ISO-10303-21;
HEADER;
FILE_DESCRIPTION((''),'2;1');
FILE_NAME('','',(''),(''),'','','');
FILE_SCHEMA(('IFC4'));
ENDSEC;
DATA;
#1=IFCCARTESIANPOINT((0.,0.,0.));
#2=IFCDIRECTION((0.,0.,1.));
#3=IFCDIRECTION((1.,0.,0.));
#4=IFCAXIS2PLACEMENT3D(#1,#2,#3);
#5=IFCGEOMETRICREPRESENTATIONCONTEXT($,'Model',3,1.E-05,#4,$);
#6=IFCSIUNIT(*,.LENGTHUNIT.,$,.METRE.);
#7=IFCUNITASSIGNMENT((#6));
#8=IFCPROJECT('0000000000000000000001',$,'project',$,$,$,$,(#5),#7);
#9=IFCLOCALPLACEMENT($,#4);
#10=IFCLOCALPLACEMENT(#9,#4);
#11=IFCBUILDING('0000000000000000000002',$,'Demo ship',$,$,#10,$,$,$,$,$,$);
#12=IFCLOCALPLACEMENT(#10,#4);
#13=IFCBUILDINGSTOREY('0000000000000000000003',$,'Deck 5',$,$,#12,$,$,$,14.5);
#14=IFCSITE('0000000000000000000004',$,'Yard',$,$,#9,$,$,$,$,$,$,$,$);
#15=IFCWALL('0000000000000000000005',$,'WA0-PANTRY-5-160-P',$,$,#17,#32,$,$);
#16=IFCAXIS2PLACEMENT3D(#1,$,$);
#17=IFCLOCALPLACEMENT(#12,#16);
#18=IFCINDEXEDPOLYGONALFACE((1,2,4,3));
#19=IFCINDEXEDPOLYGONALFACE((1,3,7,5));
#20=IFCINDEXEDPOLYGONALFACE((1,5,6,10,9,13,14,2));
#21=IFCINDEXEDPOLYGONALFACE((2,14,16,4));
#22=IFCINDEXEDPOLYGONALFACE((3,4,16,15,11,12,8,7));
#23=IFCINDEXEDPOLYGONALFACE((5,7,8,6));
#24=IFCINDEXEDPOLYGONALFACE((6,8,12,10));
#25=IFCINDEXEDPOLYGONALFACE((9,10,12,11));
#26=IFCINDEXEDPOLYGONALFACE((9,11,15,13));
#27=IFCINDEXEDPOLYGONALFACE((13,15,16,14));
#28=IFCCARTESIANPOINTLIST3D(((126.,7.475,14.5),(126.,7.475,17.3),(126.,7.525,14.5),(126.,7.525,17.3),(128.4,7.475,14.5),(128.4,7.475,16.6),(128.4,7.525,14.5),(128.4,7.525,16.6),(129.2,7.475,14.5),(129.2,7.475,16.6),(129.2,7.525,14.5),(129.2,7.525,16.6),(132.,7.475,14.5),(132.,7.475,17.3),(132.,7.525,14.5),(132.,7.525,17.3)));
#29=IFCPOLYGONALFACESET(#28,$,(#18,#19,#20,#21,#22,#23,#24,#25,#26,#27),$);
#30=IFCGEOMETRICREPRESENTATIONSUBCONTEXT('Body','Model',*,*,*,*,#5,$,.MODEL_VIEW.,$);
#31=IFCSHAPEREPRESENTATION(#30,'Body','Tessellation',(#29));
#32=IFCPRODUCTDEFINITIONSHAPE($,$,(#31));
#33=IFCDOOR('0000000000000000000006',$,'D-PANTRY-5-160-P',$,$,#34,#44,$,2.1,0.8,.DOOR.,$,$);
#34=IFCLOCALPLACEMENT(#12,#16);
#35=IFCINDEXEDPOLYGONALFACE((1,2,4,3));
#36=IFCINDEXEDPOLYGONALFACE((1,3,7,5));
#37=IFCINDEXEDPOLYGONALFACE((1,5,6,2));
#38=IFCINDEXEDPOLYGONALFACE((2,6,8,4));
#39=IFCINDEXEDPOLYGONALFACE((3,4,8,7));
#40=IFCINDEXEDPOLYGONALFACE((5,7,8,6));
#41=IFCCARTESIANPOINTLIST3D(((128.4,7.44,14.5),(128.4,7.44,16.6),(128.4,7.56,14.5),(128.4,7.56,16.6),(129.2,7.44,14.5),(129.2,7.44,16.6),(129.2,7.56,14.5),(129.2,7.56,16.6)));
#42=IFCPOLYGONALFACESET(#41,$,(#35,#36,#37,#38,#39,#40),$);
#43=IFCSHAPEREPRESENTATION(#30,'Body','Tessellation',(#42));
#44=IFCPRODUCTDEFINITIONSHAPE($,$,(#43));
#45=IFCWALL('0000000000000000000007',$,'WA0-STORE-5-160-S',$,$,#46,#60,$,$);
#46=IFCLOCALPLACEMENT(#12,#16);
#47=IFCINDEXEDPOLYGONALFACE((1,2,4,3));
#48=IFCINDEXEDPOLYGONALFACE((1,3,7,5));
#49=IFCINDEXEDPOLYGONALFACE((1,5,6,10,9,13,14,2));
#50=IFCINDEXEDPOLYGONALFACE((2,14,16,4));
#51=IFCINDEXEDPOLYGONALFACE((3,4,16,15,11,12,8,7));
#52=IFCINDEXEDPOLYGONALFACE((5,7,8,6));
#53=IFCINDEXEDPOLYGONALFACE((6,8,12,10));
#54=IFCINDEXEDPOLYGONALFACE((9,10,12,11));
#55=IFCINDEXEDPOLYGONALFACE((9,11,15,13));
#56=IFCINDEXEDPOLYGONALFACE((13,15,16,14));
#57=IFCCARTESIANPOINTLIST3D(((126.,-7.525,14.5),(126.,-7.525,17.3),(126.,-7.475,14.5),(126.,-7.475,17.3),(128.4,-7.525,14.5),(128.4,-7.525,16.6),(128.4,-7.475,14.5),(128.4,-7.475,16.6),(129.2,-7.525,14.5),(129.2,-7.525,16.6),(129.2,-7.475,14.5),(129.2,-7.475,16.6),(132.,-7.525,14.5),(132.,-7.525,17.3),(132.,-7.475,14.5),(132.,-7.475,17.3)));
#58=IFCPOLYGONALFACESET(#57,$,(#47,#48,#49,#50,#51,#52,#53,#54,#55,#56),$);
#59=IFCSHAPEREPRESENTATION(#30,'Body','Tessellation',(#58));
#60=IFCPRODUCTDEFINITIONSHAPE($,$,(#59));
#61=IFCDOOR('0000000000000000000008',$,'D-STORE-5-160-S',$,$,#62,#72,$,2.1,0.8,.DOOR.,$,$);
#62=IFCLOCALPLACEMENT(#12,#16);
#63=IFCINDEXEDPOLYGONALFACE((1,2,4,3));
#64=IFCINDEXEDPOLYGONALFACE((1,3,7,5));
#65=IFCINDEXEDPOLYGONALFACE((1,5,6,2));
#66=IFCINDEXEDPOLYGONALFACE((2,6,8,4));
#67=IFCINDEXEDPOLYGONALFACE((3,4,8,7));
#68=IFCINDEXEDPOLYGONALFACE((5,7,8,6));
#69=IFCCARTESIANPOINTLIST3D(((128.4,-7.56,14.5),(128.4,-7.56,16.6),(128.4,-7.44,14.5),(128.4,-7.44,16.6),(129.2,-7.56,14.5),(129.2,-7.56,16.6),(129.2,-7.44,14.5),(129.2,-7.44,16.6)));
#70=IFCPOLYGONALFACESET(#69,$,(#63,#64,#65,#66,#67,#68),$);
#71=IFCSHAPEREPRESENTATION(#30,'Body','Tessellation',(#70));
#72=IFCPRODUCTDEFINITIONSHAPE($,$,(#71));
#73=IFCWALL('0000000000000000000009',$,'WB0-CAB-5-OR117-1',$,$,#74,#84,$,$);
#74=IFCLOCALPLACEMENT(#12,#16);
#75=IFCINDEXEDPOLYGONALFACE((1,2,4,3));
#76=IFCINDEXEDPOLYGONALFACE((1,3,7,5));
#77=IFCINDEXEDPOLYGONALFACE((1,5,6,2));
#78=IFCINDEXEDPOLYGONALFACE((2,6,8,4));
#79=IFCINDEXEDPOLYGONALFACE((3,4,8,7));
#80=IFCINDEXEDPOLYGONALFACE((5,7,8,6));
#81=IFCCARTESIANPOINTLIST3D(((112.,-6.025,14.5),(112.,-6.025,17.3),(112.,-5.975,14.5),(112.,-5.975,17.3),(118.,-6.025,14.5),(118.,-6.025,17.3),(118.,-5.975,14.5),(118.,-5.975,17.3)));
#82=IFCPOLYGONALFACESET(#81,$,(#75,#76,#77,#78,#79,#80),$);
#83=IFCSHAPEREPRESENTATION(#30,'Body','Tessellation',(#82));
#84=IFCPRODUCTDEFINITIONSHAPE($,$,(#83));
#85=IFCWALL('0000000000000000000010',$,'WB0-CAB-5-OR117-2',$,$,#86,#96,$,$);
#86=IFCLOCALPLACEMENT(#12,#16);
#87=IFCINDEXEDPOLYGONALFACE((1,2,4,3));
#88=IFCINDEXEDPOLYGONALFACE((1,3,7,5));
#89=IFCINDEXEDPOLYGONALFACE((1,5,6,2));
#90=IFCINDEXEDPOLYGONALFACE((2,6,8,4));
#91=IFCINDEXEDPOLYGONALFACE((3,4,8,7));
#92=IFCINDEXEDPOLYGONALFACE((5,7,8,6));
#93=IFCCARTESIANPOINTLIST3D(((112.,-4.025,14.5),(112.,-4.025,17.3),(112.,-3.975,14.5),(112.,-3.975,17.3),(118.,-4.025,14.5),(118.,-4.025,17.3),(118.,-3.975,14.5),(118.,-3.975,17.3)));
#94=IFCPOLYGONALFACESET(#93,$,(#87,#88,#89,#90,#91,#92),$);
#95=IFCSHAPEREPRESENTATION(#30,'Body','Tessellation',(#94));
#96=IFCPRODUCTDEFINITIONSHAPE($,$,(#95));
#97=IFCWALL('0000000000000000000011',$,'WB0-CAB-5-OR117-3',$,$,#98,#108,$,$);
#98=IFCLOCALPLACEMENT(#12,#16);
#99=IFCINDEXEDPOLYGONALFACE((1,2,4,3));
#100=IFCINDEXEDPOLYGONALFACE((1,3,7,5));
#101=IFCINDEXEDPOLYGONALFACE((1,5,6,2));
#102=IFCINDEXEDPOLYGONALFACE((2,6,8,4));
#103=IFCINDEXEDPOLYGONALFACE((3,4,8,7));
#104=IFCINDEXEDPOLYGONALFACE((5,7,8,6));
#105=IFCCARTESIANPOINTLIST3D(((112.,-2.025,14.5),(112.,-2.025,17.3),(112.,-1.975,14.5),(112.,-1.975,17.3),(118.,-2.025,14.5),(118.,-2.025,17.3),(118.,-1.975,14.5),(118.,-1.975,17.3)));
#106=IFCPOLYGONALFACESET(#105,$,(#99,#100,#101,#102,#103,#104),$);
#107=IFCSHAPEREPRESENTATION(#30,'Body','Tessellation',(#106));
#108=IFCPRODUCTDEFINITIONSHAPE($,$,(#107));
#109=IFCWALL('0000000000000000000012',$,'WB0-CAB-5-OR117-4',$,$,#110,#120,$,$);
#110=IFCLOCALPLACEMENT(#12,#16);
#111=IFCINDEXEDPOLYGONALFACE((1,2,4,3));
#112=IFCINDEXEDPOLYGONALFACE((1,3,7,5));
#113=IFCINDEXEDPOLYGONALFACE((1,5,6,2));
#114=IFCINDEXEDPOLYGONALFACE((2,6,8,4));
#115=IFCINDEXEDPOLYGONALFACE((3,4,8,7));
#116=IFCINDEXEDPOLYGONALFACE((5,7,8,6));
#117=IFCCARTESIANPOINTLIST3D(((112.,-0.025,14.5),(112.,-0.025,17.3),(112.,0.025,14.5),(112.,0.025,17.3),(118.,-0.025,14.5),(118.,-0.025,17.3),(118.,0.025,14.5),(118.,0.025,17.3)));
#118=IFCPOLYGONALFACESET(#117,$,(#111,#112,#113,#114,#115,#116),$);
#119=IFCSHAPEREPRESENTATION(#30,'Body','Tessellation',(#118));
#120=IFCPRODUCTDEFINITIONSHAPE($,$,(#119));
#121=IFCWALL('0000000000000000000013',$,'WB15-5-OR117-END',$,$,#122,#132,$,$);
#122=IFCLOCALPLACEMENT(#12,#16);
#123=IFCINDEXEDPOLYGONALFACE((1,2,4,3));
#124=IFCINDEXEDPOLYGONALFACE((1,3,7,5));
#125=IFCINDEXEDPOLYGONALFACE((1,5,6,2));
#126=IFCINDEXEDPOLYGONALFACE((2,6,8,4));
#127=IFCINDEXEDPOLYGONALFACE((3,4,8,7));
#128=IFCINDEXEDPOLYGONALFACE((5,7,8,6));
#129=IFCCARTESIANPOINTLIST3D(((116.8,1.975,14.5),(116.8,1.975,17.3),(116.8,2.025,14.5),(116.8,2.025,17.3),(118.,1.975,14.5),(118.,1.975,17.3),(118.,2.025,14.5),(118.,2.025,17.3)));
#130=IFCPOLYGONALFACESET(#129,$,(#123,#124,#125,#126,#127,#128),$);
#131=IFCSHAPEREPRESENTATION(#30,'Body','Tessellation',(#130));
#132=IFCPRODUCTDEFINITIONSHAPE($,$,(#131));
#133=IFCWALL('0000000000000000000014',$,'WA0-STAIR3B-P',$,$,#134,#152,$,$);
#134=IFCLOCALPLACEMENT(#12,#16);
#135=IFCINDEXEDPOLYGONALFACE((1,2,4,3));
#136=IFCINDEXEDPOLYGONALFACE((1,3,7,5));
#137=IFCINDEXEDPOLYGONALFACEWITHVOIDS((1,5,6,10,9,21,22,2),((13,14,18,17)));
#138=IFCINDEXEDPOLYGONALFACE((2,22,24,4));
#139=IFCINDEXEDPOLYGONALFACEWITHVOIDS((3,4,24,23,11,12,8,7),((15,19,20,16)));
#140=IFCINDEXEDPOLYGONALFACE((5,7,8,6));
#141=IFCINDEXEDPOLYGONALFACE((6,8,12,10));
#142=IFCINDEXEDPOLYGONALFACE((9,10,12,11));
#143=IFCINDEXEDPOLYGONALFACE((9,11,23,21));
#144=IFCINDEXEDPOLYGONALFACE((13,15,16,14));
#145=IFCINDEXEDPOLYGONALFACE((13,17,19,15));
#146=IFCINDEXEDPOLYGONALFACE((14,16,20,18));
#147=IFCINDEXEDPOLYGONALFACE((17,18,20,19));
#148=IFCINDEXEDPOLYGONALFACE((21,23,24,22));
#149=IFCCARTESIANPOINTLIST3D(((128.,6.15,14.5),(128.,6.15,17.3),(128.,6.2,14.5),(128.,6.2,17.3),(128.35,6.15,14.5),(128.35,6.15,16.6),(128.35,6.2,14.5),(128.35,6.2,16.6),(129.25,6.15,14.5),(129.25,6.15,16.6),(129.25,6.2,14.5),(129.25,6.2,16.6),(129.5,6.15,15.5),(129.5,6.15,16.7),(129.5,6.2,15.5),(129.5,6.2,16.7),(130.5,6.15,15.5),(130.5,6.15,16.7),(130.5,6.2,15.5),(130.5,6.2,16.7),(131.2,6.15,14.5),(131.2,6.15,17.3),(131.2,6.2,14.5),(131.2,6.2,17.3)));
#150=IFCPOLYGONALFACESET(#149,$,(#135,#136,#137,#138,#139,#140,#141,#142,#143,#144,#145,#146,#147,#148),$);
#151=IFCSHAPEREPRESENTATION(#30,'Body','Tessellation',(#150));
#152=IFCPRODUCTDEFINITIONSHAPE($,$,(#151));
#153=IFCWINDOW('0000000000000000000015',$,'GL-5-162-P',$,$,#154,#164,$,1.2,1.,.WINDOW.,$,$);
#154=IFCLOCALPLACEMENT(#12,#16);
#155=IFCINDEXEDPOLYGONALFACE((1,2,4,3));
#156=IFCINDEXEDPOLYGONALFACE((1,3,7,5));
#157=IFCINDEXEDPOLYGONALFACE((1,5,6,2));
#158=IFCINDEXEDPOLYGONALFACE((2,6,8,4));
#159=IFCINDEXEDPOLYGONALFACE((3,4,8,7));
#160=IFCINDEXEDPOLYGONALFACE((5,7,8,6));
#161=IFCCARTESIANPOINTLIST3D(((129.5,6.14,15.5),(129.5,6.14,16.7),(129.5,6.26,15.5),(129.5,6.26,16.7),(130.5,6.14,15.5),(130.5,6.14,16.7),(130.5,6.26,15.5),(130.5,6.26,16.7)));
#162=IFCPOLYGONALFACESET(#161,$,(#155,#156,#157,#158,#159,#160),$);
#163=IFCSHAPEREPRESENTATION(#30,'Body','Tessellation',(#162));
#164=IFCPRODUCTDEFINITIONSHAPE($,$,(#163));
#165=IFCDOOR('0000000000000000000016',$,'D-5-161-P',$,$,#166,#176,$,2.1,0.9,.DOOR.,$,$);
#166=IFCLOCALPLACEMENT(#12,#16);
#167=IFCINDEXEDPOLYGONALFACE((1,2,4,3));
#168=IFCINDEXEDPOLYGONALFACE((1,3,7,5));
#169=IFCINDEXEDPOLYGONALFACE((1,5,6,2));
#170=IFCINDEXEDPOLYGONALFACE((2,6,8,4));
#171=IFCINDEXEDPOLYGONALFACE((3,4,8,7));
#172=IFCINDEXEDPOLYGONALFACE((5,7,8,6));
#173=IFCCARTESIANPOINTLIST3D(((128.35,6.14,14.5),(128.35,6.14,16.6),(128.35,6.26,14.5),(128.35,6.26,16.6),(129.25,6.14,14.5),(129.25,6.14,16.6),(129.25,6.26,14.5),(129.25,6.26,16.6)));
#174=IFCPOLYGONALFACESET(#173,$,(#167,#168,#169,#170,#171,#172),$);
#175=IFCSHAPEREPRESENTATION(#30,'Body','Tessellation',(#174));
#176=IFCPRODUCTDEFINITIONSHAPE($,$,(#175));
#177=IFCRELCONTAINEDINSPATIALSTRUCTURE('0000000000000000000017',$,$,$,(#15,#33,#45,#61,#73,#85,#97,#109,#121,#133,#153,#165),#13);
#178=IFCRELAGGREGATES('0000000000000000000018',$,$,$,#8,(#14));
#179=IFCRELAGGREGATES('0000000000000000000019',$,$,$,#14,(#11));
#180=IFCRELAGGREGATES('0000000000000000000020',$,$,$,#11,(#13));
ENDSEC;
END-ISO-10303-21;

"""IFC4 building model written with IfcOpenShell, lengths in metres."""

from ifc_helpers import new_model, si_unit, frame, frame_2d, origin, origin_with_axes, place, context, subcontext, project, spatial, rectangle, extrude, element, fill, save


model = new_model("IFC4")

# Units and contexts
model_context = context("Model", 3, precision=1e-05, world=origin_with_axes())
body_context = subcontext(model_context, "Body", "Model", "MODEL_VIEW")
ifc_project = project(units=[si_unit("LENGTHUNIT", "METRE")], contexts=[model_context])

# Site, building, storey
site_placement = place(None, origin_with_axes())
site = spatial("IfcSite", under=ifc_project, at=site_placement, Name="Yard")
building_placement = place(site_placement, origin_with_axes())
building = spatial("IfcBuilding", under=site, at=building_placement, Name="Demo ship")
storey_placement = place(building_placement, origin_with_axes())
storey = spatial("IfcBuildingStorey", under=building, at=storey_placement, Name="Deck 5", Elevation=14.5)

# Walls, openings, doors
wall_1_placement = place(storey_placement, frame((126.0, 7.475, 14.5), z_axis=(0.0, 0.0, 1.0), x_axis=(1.0, 0.0, 0.0)))
wall_1 = element("IfcWall", 1, at=wall_1_placement, inside=storey, Name="WA0-PANTRY-5-160-P", context=body_context, shape_type="SweptSolid", body=[
    extrude(rectangle(XDim=6.0, YDim=0.05, at=frame_2d((3.0, 0.025))), origin(), (0.0, 0.0, 1.0), 2.8),
])
opening_1_placement = place(None, frame((128.4, 7.44, 14.5), z_axis=(0.0, 0.0, 1.0), x_axis=(1.0, 0.0, 0.0)))
opening_1 = element("IfcOpeningElement", 2, at=opening_1_placement, cuts=wall_1, context=body_context, shape_type="SweptSolid", body=[
    extrude(rectangle(XDim=0.8, YDim=0.12, at=frame_2d((0.4, 0.06))), origin(), (0.0, 0.0, 1.0), 2.1),
])
door_1_placement = place(storey_placement, frame((128.4, 7.44, 14.5), z_axis=(0.0, 0.0, 1.0), x_axis=(1.0, 0.0, 0.0)))
door_1 = element("IfcDoor", 3, at=door_1_placement, inside=storey, Name="D-PANTRY-5-160-P", OverallHeight=2.1, OverallWidth=0.8, PredefinedType="DOOR", context=body_context, shape_type="SweptSolid", body=[
    extrude(rectangle(XDim=0.8, YDim=0.12, at=frame_2d((0.4, 0.06))), origin(), (0.0, 0.0, 1.0), 2.1),
])
fill(opening_1, door_1)
wall_2_placement = place(storey_placement, frame((126.0, -7.525, 14.5), z_axis=(0.0, 0.0, 1.0), x_axis=(1.0, 0.0, 0.0)))
wall_2 = element("IfcWall", 4, at=wall_2_placement, inside=storey, Name="WA0-STORE-5-160-S", context=body_context, shape_type="SweptSolid", body=[
    extrude(rectangle(XDim=6.0, YDim=0.05, at=frame_2d((3.0, 0.025))), origin(), (0.0, 0.0, 1.0), 2.8),
])
opening_2_placement = place(None, frame((128.4, -7.56, 14.5), z_axis=(0.0, 0.0, 1.0), x_axis=(1.0, 0.0, 0.0)))
opening_2 = element("IfcOpeningElement", 5, at=opening_2_placement, cuts=wall_2, context=body_context, shape_type="SweptSolid", body=[
    extrude(rectangle(XDim=0.8, YDim=0.12, at=frame_2d((0.4, 0.06))), origin(), (0.0, 0.0, 1.0), 2.1),
])
door_2_placement = place(storey_placement, frame((128.4, -7.56, 14.5), z_axis=(0.0, 0.0, 1.0), x_axis=(1.0, 0.0, 0.0)))
door_2 = element("IfcDoor", 6, at=door_2_placement, inside=storey, Name="D-STORE-5-160-S", OverallHeight=2.1, OverallWidth=0.8, PredefinedType="DOOR", context=body_context, shape_type="SweptSolid", body=[
    extrude(rectangle(XDim=0.8, YDim=0.12, at=frame_2d((0.4, 0.06))), origin(), (0.0, 0.0, 1.0), 2.1),
])
fill(opening_2, door_2)

# Walls
wall_3_placement = place(storey_placement, frame((112.0, -6.025, 14.5), z_axis=(0.0, 0.0, 1.0), x_axis=(1.0, 0.0, 0.0)))
element("IfcWall", 7, at=wall_3_placement, inside=storey, Name="WB0-CAB-5-OR117-1", context=body_context, shape_type="SweptSolid", body=[
    extrude(rectangle(XDim=6.0, YDim=0.05, at=frame_2d((3.0, 0.025))), origin(), (0.0, 0.0, 1.0), 2.8),
])
wall_4_placement = place(storey_placement, frame((112.0, -4.025, 14.5), z_axis=(0.0, 0.0, 1.0), x_axis=(1.0, 0.0, 0.0)))
element("IfcWall", 8, at=wall_4_placement, inside=storey, Name="WB0-CAB-5-OR117-2", context=body_context, shape_type="SweptSolid", body=[
    extrude(rectangle(XDim=6.0, YDim=0.05, at=frame_2d((3.0, 0.025))), origin(), (0.0, 0.0, 1.0), 2.8),
])
wall_5_placement = place(storey_placement, frame((112.0, -2.025, 14.5), z_axis=(0.0, 0.0, 1.0), x_axis=(1.0, 0.0, 0.0)))
element("IfcWall", 9, at=wall_5_placement, inside=storey, Name="WB0-CAB-5-OR117-3", context=body_context, shape_type="SweptSolid", body=[
    extrude(rectangle(XDim=6.0, YDim=0.05, at=frame_2d((3.0, 0.025))), origin(), (0.0, 0.0, 1.0), 2.8),
])
wall_6_placement = place(storey_placement, frame((112.0, -0.025, 14.5), z_axis=(0.0, 0.0, 1.0), x_axis=(1.0, 0.0, 0.0)))
element("IfcWall", 10, at=wall_6_placement, inside=storey, Name="WB0-CAB-5-OR117-4", context=body_context, shape_type="SweptSolid", body=[
    extrude(rectangle(XDim=6.0, YDim=0.05, at=frame_2d((3.0, 0.025))), origin(), (0.0, 0.0, 1.0), 2.8),
])
wall_7_placement = place(storey_placement, frame((116.8, 1.975, 14.5), z_axis=(0.0, 0.0, 1.0), x_axis=(1.0, 0.0, 0.0)))
element("IfcWall", 11, at=wall_7_placement, inside=storey, Name="WB15-5-OR117-END", context=body_context, shape_type="SweptSolid", body=[
    extrude(rectangle(XDim=1.2, YDim=0.05, at=frame_2d((0.6, 0.025))), origin(), (0.0, 0.0, 1.0), 2.8),
])

# Wall, openings, window, door
wall_8_placement = place(storey_placement, frame((128.0, 6.15, 14.5), z_axis=(0.0, 0.0, 1.0), x_axis=(1.0, 0.0, 0.0)))
wall_8 = element("IfcWall", 12, at=wall_8_placement, inside=storey, Name="WA0-STAIR3B-P", context=body_context, shape_type="SweptSolid", body=[
    extrude(rectangle(XDim=3.2, YDim=0.05, at=frame_2d((1.6, 0.025))), origin(), (0.0, 0.0, 1.0), 2.8),
])
opening_3_placement = place(None, frame((129.5, 6.14, 15.5), z_axis=(0.0, 0.0, 1.0), x_axis=(1.0, 0.0, 0.0)))
opening_3 = element("IfcOpeningElement", 13, at=opening_3_placement, cuts=wall_8, context=body_context, shape_type="SweptSolid", body=[
    extrude(rectangle(XDim=1.0, YDim=0.12, at=frame_2d((0.5, 0.06))), origin(), (0.0, 0.0, 1.0), 1.2),
])
opening_4_placement = place(None, frame((128.35, 6.14, 14.5), z_axis=(0.0, 0.0, 1.0), x_axis=(1.0, 0.0, 0.0)))
opening_4 = element("IfcOpeningElement", 14, at=opening_4_placement, cuts=wall_8, context=body_context, shape_type="SweptSolid", body=[
    extrude(rectangle(XDim=0.9, YDim=0.12, at=frame_2d((0.45, 0.06))), origin(), (0.0, 0.0, 1.0), 2.1),
])
window_placement = place(storey_placement, frame((129.5, 6.14, 15.5), z_axis=(0.0, 0.0, 1.0), x_axis=(1.0, 0.0, 0.0)))
window = element("IfcWindow", 15, at=window_placement, inside=storey, Name="GL-5-162-P", OverallHeight=1.2, OverallWidth=1.0, PredefinedType="WINDOW", context=body_context, shape_type="SweptSolid", body=[
    extrude(rectangle(XDim=1.0, YDim=0.12, at=frame_2d((0.5, 0.06))), origin(), (0.0, 0.0, 1.0), 1.2),
])
fill(opening_3, window)
door_3_placement = place(storey_placement, frame((128.35, 6.14, 14.5), z_axis=(0.0, 0.0, 1.0), x_axis=(1.0, 0.0, 0.0)))
door_3 = element("IfcDoor", 16, at=door_3_placement, inside=storey, Name="D-5-161-P", OverallHeight=2.1, OverallWidth=0.9, PredefinedType="DOOR", context=body_context, shape_type="SweptSolid", body=[
    extrude(rectangle(XDim=0.9, YDim=0.12, at=frame_2d((0.45, 0.06))), origin(), (0.0, 0.0, 1.0), 2.1),
])
fill(opening_4, door_3)

save(model, "model.ifc")
